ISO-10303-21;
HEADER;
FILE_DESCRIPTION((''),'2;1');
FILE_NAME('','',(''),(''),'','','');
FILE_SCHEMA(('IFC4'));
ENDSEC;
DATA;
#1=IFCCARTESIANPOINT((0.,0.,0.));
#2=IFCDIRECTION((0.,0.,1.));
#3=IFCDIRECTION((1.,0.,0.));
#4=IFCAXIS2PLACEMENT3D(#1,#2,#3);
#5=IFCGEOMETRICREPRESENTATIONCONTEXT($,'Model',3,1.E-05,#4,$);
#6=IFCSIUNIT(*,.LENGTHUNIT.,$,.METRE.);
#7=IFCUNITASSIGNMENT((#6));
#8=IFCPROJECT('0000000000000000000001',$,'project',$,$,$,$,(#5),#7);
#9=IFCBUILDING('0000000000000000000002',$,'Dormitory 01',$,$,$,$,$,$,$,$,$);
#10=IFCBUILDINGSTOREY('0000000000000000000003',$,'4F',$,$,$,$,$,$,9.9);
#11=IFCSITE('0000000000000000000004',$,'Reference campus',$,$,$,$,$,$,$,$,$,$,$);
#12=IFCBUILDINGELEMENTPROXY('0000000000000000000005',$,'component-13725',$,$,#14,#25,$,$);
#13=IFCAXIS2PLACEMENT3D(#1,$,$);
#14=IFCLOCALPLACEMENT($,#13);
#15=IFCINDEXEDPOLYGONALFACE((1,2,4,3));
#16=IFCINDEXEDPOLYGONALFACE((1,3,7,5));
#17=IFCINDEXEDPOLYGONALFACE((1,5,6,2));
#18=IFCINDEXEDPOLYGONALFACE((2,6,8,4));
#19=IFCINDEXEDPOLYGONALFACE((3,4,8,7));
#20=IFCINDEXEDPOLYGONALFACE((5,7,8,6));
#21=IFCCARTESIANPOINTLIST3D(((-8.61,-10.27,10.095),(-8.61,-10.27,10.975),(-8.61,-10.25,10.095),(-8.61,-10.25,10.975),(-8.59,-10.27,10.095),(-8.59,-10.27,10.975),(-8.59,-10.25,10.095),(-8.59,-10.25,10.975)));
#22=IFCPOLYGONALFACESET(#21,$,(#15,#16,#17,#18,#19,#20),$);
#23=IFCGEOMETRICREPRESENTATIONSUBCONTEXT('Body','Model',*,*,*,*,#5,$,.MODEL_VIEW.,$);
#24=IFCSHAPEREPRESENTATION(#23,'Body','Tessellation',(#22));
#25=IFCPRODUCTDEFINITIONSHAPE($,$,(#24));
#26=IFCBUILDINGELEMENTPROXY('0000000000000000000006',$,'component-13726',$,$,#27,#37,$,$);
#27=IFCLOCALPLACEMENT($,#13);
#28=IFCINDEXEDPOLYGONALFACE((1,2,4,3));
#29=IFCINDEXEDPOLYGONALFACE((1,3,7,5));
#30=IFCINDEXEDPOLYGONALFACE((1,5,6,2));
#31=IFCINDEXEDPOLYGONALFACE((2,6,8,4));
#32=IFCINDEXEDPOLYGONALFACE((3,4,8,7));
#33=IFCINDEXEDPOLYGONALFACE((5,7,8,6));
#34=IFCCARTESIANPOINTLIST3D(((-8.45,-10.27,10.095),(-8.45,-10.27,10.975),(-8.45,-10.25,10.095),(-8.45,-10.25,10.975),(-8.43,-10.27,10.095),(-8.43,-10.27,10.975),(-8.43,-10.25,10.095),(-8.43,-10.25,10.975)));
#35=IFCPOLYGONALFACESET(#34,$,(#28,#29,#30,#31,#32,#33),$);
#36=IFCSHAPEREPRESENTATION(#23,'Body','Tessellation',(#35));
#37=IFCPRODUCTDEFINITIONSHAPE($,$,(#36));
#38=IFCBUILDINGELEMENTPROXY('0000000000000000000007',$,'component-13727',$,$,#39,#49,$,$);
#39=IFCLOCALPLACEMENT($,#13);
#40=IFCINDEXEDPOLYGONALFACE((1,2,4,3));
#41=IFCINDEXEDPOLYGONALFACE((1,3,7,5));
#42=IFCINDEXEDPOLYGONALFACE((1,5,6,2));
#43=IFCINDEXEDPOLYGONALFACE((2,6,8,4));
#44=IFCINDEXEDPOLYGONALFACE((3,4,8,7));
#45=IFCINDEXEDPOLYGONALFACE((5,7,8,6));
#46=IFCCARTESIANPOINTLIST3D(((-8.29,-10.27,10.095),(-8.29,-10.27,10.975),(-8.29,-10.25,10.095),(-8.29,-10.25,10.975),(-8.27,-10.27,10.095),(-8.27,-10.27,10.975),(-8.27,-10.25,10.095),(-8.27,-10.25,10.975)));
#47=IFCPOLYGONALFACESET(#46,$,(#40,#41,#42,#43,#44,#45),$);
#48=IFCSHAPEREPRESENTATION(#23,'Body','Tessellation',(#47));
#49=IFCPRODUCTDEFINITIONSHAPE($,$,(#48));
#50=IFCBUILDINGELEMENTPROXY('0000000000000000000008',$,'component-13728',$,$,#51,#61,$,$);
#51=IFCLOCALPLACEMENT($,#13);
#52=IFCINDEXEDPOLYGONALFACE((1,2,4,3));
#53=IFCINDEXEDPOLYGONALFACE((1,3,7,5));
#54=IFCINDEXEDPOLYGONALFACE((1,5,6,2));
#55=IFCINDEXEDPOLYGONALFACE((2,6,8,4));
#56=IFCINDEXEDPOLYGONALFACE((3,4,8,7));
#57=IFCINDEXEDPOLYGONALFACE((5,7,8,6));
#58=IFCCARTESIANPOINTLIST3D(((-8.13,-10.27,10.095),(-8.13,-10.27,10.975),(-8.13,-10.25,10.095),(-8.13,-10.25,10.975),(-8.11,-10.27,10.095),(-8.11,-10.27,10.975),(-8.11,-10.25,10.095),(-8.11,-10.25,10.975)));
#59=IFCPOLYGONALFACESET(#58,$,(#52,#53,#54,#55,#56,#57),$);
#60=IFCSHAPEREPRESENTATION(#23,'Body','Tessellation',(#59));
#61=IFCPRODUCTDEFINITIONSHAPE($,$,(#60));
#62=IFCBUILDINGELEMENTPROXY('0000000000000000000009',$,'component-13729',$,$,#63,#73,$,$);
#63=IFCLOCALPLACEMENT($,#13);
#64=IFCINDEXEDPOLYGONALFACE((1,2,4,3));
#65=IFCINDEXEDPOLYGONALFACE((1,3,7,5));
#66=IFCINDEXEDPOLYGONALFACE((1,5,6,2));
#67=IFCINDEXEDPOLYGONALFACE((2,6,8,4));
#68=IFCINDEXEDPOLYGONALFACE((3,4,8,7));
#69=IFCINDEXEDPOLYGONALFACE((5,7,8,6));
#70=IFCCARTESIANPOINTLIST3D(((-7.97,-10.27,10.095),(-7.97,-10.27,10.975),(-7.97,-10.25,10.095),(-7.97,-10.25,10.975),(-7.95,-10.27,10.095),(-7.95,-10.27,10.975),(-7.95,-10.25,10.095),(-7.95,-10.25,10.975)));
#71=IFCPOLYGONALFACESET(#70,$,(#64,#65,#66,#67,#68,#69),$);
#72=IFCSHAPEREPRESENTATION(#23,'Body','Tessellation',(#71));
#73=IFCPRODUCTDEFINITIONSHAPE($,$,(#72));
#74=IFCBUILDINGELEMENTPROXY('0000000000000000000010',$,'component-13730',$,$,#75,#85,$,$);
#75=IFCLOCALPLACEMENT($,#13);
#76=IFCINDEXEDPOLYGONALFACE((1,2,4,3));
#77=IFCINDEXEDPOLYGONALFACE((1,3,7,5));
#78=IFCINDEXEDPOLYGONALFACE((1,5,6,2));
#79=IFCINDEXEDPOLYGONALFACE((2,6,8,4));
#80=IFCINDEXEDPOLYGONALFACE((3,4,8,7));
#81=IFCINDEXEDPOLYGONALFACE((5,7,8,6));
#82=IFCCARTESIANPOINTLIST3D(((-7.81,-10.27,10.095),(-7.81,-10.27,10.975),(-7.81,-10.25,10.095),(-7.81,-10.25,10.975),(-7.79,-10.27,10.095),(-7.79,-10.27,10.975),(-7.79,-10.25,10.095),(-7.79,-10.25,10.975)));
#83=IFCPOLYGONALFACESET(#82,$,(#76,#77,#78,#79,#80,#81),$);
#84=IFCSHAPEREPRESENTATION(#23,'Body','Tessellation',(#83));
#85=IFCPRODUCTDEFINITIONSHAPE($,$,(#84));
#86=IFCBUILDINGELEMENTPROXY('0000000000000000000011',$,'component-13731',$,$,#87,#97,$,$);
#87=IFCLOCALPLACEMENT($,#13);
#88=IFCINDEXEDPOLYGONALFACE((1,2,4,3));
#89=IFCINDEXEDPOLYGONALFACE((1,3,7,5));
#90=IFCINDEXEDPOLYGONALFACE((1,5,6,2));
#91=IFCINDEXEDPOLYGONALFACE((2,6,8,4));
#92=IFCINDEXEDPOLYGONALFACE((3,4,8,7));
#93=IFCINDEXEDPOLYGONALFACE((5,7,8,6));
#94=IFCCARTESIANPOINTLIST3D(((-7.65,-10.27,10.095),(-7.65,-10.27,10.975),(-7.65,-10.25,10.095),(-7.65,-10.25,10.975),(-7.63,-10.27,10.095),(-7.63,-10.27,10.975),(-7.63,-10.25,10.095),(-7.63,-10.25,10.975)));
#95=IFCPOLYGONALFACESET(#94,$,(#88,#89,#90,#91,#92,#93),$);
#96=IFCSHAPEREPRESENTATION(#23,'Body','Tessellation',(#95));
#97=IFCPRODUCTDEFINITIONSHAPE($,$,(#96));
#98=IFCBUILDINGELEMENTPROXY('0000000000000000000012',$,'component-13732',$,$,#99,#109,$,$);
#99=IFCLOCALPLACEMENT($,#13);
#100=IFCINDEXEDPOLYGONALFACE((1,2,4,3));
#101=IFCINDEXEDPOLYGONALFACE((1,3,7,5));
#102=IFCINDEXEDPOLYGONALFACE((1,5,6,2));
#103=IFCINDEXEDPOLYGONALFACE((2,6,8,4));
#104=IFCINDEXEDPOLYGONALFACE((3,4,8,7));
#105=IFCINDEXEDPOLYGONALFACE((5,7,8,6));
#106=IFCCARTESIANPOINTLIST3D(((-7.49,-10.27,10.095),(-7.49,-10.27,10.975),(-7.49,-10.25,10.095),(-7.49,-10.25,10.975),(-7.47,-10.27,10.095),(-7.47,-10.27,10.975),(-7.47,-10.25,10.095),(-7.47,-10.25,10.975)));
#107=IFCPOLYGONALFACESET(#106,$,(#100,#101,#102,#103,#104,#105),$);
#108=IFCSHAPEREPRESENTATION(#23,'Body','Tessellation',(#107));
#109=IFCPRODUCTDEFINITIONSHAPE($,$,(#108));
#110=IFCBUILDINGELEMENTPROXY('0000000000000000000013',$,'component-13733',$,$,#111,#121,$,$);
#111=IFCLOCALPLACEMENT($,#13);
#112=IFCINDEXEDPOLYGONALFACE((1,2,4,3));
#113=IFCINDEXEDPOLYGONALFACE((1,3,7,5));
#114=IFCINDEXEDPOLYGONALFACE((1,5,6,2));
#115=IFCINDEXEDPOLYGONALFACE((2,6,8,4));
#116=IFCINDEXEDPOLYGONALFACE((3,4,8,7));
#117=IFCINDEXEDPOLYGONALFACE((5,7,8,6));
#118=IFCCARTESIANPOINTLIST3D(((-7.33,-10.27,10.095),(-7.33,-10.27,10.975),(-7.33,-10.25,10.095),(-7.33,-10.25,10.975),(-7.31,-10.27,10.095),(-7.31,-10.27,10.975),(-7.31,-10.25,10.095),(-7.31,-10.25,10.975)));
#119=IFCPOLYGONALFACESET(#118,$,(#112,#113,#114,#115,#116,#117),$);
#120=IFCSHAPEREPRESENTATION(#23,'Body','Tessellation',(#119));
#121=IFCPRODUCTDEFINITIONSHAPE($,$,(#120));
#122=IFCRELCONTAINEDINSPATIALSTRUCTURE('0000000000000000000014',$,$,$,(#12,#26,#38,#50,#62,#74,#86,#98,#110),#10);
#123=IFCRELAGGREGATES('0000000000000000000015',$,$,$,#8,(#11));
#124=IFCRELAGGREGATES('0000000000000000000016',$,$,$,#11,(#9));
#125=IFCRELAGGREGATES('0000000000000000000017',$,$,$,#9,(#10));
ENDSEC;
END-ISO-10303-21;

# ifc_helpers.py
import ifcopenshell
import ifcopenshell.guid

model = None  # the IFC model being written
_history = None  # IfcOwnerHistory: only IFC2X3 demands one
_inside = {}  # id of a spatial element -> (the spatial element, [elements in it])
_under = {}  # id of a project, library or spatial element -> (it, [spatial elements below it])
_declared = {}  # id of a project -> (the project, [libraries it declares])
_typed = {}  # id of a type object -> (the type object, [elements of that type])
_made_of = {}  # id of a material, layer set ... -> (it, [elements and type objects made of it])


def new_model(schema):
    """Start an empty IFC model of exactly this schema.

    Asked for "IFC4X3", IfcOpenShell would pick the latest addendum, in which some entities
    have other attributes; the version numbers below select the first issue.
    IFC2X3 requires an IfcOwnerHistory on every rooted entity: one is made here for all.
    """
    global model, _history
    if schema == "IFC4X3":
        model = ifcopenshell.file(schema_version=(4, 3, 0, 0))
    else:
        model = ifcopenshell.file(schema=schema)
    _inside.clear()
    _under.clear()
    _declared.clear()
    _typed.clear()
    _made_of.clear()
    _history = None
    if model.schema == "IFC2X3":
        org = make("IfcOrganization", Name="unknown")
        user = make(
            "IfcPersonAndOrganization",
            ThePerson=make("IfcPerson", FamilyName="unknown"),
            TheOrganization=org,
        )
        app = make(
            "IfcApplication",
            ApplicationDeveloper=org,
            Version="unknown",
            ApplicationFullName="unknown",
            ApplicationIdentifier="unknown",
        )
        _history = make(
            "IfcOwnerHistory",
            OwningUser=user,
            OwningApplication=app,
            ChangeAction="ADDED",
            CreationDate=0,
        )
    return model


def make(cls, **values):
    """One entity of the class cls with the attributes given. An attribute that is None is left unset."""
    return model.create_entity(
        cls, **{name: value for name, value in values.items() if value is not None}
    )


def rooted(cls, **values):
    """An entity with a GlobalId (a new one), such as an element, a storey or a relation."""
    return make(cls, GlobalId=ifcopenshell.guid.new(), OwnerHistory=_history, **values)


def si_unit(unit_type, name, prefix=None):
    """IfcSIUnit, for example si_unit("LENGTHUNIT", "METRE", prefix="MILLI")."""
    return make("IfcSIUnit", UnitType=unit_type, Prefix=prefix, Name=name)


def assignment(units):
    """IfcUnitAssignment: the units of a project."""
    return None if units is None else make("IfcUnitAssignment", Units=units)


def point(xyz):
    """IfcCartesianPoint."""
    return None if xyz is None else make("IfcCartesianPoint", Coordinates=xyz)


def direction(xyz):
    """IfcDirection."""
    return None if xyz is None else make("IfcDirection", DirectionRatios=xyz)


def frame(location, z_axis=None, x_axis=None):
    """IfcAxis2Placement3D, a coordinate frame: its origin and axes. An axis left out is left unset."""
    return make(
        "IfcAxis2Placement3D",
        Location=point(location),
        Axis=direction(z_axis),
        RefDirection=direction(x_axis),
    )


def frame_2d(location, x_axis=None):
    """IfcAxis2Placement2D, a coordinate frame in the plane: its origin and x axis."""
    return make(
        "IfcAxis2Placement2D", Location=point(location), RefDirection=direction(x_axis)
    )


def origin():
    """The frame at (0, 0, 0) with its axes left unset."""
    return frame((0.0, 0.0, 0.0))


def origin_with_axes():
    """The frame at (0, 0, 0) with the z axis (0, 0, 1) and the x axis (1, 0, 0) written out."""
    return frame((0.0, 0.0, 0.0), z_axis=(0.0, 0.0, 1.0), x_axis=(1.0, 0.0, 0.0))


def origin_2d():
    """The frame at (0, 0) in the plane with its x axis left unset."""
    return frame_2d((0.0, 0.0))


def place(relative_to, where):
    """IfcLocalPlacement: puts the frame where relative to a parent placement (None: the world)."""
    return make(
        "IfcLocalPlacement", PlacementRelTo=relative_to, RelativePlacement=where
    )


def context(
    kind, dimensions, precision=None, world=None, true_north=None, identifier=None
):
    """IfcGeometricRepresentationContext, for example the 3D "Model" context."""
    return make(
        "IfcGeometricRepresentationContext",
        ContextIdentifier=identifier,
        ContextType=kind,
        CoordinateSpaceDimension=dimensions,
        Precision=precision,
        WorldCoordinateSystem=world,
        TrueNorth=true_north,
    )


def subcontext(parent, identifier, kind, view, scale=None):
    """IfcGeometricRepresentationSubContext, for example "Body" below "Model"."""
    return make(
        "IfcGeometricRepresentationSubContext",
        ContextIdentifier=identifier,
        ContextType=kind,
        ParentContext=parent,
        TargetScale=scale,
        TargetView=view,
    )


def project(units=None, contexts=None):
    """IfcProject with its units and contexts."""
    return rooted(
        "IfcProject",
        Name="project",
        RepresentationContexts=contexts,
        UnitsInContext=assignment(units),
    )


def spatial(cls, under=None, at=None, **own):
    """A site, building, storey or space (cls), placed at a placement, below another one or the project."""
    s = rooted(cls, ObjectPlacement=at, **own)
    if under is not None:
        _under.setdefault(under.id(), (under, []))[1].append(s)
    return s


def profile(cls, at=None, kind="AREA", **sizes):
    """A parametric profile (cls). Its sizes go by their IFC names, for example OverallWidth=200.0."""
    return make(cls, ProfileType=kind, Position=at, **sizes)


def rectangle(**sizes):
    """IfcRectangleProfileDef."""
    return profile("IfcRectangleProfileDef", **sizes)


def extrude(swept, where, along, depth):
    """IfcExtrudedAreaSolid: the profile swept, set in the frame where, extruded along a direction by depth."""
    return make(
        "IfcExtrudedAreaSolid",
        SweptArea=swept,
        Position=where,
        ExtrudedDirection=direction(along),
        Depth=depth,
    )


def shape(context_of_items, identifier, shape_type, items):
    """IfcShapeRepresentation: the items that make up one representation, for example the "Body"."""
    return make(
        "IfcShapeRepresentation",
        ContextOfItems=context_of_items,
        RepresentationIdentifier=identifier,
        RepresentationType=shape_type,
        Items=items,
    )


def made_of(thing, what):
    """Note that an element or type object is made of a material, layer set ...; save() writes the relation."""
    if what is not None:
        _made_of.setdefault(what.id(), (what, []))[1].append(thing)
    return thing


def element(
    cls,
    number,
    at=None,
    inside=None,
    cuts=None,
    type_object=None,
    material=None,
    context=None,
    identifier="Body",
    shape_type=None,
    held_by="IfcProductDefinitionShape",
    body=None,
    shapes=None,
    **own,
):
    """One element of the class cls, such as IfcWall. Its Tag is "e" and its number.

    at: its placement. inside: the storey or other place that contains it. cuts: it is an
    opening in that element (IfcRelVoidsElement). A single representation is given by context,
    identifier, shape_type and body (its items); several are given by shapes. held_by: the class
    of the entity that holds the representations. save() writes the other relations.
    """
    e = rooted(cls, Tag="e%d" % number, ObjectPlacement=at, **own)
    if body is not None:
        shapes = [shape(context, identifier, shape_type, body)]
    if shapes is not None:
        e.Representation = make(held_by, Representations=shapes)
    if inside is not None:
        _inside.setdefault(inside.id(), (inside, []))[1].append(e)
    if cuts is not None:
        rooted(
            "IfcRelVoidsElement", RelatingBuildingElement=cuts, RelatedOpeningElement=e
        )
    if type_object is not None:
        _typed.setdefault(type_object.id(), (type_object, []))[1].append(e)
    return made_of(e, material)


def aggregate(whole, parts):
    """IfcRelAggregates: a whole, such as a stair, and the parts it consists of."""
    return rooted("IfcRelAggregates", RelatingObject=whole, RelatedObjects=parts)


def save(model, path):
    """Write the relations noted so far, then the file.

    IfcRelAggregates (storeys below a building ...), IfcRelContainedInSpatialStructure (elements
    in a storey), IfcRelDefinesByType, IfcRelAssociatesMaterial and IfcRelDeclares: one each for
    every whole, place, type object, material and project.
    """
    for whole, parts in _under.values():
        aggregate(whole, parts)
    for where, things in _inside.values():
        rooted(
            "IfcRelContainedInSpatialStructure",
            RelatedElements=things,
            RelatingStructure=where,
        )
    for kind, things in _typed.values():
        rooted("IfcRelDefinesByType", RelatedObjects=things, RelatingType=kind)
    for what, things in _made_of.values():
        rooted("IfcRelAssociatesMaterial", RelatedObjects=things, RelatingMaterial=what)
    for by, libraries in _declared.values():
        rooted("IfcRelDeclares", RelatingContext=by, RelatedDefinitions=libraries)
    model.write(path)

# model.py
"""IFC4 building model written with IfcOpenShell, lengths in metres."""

from ifc_helpers import new_model, si_unit, frame, origin, origin_with_axes, origin_2d, place, context, subcontext, project, spatial, rectangle, extrude, element, save


model = new_model("IFC4")

# Units and contexts
model_context = context("Model", 3, precision=1e-05, world=origin_with_axes())
body_context = subcontext(model_context, "Body", "Model", "MODEL_VIEW")
ifc_project = project(units=[si_unit("LENGTHUNIT", "METRE")], contexts=[model_context])

# Site, building, storey
site = spatial("IfcSite", under=ifc_project, Name="Reference campus")
building = spatial("IfcBuilding", under=site, Name="Dormitory 01")
storey = spatial("IfcBuildingStorey", under=building, Name="4F", Elevation=9.9)

# Building element proxies
for number, where, z_axis, x_axis, name in (
    (1, (-8.6, -10.26, 10.095), (0.0, 0.0, 1.0), (1.0, 0.0, 0.0), "component-13725"),
    (2, (-8.44, -10.26, 10.095), (0.0, 0.0, 1.0), (1.0, 0.0, 0.0), "component-13726"),
    (3, (-8.28, -10.26, 10.095), (0.0, 0.0, 1.0), (1.0, 0.0, 0.0), "component-13727"),
    (4, (-8.12, -10.26, 10.095), (0.0, 0.0, 1.0), (1.0, 0.0, 0.0), "component-13728"),
    (5, (-7.96, -10.26, 10.095), (0.0, 0.0, 1.0), (1.0, 0.0, 0.0), "component-13729"),
    (6, (-7.8, -10.26, 10.095), (0.0, 0.0, 1.0), (1.0, 0.0, 0.0), "component-13730"),
    (7, (-7.64, -10.26, 10.095), (0.0, 0.0, 1.0), (1.0, 0.0, 0.0), "component-13731"),
    (8, (-7.48, -10.26, 10.095), (0.0, 0.0, 1.0), (1.0, 0.0, 0.0), "component-13732"),
    (9, (-7.32, -10.26, 10.095), (0.0, 0.0, 1.0), (1.0, 0.0, 0.0), "component-13733"),
):
    element("IfcBuildingElementProxy", number, at=place(None, frame(where, z_axis=z_axis, x_axis=x_axis)), inside=storey, Name=name, context=body_context, shape_type="SweptSolid", body=[
        extrude(rectangle(XDim=0.02, YDim=0.02, at=origin_2d()), origin(), (0.0, 0.0, 1.0), 0.88),
    ])

save(model, "model.ifc")
